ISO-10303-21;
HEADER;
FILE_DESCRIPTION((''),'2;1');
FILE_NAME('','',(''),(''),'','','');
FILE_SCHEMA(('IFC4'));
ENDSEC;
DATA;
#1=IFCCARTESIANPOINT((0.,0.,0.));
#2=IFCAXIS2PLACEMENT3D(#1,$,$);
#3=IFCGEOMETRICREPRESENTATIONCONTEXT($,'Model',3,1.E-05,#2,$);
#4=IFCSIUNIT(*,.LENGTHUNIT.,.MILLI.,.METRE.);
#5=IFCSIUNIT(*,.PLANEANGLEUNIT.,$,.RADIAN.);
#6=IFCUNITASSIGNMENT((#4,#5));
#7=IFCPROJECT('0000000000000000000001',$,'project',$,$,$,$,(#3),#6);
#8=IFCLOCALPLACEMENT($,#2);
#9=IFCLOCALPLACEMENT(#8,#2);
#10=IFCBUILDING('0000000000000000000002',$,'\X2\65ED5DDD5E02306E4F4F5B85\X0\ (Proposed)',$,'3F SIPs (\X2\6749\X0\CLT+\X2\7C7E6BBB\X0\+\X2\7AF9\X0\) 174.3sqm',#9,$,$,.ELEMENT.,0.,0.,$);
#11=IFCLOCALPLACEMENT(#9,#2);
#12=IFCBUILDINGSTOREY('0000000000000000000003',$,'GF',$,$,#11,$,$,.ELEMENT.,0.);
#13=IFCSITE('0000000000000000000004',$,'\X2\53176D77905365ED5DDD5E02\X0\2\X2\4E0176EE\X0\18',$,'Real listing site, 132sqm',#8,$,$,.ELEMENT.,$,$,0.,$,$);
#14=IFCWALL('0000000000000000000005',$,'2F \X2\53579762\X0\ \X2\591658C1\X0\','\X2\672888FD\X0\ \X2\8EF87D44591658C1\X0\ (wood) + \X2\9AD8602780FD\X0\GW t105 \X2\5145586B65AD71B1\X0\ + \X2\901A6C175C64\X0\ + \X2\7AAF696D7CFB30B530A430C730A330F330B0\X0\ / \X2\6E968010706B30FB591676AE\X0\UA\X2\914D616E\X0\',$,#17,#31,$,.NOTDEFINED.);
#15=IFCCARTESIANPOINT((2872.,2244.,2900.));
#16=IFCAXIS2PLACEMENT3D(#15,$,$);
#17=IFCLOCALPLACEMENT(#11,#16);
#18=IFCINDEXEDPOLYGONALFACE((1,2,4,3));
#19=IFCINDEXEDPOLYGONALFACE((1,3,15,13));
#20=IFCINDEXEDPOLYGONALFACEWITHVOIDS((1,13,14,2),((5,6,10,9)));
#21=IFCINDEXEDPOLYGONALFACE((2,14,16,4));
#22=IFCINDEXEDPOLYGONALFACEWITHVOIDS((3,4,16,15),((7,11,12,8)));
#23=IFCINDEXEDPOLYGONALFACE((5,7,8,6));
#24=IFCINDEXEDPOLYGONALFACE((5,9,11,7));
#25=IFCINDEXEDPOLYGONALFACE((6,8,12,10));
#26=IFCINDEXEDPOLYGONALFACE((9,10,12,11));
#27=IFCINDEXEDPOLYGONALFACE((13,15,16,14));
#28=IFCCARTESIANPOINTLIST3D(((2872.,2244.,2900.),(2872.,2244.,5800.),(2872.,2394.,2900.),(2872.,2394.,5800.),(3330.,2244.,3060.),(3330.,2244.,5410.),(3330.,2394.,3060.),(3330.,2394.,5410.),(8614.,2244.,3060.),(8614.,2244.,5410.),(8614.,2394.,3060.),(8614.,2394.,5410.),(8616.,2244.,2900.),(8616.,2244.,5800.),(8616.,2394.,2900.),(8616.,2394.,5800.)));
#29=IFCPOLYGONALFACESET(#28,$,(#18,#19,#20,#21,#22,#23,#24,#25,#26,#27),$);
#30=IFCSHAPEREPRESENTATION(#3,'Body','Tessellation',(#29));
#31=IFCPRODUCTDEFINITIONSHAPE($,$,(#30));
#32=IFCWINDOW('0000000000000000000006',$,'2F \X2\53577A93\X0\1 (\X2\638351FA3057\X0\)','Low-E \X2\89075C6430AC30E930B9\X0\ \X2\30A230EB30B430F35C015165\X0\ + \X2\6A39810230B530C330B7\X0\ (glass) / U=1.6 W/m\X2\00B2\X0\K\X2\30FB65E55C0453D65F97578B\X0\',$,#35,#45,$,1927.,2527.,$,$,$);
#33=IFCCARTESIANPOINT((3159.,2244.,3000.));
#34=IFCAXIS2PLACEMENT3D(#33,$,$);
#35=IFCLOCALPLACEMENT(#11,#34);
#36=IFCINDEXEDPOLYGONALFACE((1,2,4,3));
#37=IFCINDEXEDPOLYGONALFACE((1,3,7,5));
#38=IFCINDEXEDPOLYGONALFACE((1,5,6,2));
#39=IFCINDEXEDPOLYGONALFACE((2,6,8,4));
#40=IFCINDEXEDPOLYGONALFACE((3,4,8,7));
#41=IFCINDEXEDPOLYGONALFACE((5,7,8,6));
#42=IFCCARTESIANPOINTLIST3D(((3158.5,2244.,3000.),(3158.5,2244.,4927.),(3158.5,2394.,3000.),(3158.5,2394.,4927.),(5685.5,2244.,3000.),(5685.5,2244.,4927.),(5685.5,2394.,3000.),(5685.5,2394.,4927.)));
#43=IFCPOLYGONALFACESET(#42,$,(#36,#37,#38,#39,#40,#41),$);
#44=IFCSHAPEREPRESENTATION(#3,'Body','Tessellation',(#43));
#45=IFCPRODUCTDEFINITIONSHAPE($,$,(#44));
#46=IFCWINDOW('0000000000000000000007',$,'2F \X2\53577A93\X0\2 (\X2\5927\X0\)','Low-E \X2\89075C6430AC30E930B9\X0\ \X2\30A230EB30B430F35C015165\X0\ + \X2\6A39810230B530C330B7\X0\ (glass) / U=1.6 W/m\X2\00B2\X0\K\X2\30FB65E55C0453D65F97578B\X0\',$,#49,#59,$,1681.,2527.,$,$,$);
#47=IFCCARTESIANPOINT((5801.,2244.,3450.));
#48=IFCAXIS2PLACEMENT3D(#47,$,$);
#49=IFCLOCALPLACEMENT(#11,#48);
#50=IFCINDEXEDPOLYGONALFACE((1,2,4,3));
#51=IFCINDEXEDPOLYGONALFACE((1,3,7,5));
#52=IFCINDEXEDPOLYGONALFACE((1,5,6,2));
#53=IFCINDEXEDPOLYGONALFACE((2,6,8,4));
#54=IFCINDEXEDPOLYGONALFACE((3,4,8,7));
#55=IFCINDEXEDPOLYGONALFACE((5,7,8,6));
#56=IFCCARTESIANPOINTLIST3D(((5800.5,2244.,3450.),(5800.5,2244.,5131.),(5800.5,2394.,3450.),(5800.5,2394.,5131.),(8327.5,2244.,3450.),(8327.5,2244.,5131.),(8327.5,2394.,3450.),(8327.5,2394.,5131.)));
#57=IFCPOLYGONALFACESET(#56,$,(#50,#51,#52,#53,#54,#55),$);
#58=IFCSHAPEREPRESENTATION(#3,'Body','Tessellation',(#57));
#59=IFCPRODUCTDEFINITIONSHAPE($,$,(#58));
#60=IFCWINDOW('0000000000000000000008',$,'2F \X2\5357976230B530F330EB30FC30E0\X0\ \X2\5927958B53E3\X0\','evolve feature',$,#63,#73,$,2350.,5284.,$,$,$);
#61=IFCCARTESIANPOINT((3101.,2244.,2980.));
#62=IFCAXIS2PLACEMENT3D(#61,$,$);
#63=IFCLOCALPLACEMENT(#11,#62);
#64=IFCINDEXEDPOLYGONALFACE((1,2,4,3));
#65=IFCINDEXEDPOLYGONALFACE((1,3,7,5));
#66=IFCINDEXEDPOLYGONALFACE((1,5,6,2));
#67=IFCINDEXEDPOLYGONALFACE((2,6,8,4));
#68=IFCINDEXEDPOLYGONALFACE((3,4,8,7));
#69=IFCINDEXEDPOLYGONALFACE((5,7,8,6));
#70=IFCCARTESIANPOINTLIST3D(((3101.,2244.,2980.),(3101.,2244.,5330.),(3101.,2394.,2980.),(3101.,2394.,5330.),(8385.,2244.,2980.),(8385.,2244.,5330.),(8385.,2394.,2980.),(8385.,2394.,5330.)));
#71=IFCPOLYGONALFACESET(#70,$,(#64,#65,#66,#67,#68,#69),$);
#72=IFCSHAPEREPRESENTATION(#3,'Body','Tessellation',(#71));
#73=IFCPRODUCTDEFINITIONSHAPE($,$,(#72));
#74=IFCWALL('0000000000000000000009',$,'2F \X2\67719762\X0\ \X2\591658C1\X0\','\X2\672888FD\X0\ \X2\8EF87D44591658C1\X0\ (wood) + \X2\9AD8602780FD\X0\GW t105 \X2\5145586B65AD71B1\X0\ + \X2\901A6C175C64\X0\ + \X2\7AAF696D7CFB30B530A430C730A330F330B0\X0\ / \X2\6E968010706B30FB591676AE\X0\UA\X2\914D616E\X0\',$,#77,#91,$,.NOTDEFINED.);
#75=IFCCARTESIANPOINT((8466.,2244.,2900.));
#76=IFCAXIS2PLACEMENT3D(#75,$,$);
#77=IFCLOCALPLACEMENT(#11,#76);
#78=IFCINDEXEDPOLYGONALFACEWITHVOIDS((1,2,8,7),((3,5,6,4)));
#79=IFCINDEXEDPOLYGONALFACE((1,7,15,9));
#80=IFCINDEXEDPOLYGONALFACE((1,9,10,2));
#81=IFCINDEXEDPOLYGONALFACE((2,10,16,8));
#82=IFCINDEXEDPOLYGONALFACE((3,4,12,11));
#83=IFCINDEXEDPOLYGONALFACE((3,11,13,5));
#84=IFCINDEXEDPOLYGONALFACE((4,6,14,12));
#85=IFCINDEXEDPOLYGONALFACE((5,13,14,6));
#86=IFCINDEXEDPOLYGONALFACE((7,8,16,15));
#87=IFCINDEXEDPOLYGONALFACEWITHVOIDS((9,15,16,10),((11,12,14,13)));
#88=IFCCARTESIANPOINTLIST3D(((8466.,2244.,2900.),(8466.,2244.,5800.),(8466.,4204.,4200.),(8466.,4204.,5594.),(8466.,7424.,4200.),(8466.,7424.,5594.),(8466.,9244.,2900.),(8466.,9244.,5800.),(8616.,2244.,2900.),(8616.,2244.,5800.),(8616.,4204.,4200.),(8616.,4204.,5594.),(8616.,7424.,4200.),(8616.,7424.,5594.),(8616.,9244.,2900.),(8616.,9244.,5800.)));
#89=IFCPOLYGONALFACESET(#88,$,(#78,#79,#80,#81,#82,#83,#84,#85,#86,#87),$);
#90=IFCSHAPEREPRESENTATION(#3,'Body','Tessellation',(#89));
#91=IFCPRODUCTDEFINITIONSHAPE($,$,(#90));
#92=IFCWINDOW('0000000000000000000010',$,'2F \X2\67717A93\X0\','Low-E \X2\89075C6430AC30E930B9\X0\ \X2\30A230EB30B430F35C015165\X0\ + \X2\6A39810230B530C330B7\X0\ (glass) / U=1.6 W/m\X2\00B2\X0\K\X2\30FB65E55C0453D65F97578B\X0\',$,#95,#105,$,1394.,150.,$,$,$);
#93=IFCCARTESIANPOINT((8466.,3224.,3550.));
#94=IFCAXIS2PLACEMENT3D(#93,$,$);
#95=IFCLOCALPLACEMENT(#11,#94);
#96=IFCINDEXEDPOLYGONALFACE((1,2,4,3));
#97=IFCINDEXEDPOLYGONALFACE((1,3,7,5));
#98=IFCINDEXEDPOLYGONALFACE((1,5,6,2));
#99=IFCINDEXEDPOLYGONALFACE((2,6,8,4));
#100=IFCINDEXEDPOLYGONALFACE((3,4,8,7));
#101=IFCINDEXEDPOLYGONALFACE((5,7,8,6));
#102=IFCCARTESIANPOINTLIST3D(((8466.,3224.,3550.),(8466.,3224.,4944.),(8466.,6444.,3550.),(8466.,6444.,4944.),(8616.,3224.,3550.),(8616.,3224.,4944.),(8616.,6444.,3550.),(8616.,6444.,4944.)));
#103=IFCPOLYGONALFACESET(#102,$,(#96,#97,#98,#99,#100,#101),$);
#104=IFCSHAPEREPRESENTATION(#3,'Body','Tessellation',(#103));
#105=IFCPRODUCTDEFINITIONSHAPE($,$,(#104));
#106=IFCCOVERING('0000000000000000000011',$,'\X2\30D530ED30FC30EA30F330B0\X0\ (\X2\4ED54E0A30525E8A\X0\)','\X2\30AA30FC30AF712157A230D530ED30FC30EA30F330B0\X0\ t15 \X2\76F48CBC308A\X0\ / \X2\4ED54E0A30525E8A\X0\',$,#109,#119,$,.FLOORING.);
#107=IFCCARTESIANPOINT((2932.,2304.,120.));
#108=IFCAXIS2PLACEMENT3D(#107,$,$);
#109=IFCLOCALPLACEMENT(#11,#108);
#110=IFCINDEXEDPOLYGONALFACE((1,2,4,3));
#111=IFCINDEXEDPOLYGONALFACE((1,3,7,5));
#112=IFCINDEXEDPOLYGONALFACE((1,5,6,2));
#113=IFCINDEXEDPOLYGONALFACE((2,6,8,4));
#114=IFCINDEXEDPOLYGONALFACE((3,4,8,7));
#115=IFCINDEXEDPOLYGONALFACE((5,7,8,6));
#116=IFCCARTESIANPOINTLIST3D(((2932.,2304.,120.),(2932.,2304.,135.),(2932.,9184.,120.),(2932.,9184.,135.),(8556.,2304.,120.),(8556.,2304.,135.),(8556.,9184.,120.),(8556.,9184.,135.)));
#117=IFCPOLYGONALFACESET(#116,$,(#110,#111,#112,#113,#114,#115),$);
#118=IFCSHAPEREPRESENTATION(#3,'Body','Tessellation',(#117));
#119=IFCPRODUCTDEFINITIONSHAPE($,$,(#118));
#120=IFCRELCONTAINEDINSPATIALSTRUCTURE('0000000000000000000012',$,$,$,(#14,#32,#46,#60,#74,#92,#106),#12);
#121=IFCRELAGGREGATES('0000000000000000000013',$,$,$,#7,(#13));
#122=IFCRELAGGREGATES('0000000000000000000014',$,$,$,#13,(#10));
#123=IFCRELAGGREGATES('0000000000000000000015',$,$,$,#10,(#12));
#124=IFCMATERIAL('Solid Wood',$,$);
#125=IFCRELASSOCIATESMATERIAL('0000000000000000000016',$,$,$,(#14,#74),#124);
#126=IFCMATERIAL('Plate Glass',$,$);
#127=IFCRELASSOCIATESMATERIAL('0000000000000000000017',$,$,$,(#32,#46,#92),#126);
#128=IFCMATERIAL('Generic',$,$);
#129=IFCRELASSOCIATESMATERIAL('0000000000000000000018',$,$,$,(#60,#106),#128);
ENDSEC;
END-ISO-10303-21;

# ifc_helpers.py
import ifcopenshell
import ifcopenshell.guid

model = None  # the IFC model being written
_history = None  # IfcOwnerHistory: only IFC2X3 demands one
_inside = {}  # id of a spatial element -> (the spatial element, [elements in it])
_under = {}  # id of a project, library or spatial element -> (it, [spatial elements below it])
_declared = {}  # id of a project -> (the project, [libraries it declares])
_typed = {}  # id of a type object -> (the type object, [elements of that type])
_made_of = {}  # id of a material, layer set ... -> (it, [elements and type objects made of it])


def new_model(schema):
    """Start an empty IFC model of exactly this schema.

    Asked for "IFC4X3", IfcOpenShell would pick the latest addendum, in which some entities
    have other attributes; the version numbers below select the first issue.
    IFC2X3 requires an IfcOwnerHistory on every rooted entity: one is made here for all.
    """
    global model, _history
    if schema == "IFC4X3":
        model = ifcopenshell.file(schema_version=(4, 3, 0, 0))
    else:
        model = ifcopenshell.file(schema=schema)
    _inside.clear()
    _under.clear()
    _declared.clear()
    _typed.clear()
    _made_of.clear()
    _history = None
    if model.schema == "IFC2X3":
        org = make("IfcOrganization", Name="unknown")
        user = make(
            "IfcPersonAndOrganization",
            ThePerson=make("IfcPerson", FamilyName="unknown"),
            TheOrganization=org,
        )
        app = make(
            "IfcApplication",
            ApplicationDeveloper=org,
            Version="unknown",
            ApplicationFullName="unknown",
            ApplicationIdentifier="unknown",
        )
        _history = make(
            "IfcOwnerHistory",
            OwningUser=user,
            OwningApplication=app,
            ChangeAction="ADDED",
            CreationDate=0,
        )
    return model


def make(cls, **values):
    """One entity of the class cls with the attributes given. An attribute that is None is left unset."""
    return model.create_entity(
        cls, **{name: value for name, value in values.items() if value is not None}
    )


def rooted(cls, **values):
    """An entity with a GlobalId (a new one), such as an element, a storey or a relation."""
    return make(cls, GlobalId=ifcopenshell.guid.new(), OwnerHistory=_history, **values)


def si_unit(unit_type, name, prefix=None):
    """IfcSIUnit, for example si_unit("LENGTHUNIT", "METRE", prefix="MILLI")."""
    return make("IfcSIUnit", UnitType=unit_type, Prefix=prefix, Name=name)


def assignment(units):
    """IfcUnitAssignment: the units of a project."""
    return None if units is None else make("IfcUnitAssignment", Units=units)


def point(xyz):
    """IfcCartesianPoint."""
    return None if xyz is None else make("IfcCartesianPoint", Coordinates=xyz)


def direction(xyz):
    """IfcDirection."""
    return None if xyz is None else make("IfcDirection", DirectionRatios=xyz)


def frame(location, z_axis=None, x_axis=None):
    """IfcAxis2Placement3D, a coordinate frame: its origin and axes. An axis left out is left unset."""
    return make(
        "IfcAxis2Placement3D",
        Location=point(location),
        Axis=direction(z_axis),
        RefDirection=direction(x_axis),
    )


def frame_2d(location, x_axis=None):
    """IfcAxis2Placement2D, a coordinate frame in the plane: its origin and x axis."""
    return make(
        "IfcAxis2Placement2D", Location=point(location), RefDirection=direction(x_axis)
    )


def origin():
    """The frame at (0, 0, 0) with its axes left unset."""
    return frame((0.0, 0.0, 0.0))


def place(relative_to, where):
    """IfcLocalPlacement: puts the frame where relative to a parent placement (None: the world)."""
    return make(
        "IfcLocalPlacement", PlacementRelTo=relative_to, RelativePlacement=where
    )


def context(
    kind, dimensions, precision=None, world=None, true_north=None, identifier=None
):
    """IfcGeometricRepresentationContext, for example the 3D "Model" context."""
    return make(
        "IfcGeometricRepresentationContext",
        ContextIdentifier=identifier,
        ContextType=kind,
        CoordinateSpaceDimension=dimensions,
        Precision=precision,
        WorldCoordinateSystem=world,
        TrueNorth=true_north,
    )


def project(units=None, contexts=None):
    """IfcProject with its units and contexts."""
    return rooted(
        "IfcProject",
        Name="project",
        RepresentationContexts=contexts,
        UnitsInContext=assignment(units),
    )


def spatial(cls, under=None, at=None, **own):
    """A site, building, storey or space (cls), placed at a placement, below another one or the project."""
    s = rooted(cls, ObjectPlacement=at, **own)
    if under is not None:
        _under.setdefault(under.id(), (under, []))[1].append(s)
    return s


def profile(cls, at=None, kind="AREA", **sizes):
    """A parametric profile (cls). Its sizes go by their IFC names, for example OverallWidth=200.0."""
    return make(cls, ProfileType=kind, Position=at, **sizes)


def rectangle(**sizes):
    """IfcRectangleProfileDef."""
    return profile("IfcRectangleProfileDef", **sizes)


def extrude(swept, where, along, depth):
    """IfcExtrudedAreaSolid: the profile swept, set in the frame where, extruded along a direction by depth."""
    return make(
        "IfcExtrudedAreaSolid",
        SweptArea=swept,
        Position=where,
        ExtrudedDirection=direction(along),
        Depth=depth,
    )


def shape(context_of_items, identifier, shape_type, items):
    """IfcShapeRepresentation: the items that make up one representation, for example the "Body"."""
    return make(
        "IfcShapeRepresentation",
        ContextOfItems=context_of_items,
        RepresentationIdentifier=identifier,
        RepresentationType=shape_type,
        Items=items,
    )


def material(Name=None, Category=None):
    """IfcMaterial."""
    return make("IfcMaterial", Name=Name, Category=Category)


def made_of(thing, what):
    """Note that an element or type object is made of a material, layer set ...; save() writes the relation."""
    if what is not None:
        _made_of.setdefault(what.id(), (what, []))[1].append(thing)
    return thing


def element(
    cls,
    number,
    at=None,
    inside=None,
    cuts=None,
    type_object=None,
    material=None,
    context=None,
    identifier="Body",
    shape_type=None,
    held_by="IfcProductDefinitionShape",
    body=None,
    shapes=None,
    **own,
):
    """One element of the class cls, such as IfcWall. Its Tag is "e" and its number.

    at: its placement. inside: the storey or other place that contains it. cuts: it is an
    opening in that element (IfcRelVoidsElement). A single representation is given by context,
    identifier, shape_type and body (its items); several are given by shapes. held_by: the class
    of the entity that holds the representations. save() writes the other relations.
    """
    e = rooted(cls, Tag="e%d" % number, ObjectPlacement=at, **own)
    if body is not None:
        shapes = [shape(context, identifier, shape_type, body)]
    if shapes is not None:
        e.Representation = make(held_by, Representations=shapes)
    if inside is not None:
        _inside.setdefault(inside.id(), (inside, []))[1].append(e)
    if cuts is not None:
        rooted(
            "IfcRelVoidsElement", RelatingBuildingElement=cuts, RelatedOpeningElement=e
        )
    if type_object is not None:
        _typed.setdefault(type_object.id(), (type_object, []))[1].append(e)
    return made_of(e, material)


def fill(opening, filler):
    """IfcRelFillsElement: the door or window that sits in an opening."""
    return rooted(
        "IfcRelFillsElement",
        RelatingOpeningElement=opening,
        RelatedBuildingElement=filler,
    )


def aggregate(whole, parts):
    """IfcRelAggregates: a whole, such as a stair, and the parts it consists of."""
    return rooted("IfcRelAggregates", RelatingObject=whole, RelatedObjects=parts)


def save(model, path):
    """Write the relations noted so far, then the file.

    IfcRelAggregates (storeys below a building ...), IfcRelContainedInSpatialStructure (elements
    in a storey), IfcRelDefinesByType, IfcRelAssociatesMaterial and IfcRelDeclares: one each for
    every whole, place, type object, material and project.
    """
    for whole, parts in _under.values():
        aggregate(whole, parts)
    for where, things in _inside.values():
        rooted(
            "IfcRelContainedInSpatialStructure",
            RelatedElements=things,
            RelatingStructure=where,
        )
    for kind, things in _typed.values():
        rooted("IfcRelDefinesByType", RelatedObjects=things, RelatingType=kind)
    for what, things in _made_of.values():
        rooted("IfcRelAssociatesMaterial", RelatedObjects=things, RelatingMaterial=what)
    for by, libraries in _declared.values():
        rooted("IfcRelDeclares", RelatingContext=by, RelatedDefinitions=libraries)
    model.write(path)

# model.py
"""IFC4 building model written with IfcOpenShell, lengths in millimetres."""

from ifc_helpers import new_model, si_unit, frame, frame_2d, origin, place, context, project, spatial, rectangle, extrude, material, element, fill, save


model = new_model("IFC4")

# Units and contexts
model_context = context("Model", 3, precision=1e-05, world=origin())
ifc_project = project(units=[si_unit("LENGTHUNIT", "METRE", prefix="MILLI"), si_unit("PLANEANGLEUNIT", "RADIAN")], contexts=[model_context])

# Site, building, storey
site_placement = place(None, origin())
site = spatial("IfcSite", under=ifc_project, at=site_placement, Name="北海道旭川市2丁目18", ObjectType="Real listing site, 132sqm", CompositionType="ELEMENT", RefElevation=0.0)
building_placement = place(site_placement, origin())
building = spatial("IfcBuilding", under=site, at=building_placement, Name="旭川市の住宅 (Proposed)", ObjectType="3F SIPs (杉CLT+籾殻+竹) 174.3sqm", CompositionType="ELEMENT", ElevationOfRefHeight=0.0, ElevationOfTerrain=0.0)
storey_placement = place(building_placement, origin())
storey = spatial("IfcBuildingStorey", under=building, at=storey_placement, Name="GF", CompositionType="ELEMENT", Elevation=0.0)

# Shared definitions
ifc_material_1 = material(Name="Solid Wood")
ifc_material_2 = material(Name="Generic")

# Shared definitions
ifc_material_3 = material(Name="Plate Glass")

# Wall, openings, windows
wall_1_placement = place(storey_placement, frame((2872.0, 2244.0, 2900.0)))
wall_1 = element("IfcWall", 1, at=wall_1_placement, inside=storey, material=ifc_material_1, Name="2F 南面 外壁", Description="木製 軸組外壁 (wood) + 高性能GW t105 充填断熱 + 通気層 + 窯業系サイディング / 準耐火・外皮UA配慮", PredefinedType="NOTDEFINED", context=model_context, shape_type="SweptSolid", body=[
    extrude(rectangle(XDim=5744.0, YDim=150.0, at=frame_2d((2872.0, 75.0))), frame((2872.0, 2244.0, 2900.0)), (0.0, 0.0, 1.0), 2900.0),
])
opening_1_placement = place(storey_placement, frame((3159.0, 2244.0, 3000.0)))
opening_1 = element("IfcOpeningElement", 2, at=opening_1_placement, cuts=wall_1, PredefinedType="NOTDEFINED", context=model_context, shape_type="SweptSolid", body=[
    extrude(rectangle(XDim=2527.0, YDim=150.0, at=frame_2d((1263.0, 75.0))), frame((3159.0, 2244.0, 3000.0)), (0.0, 0.0, 1.0), 1927.0),
])
opening_2_placement = place(storey_placement, frame((5801.0, 2244.0, 3450.0)))
opening_2 = element("IfcOpeningElement", 3, at=opening_2_placement, cuts=wall_1, PredefinedType="NOTDEFINED", context=model_context, shape_type="SweptSolid", body=[
    extrude(rectangle(XDim=2527.0, YDim=150.0, at=frame_2d((1263.0, 75.0))), frame((5801.0, 2244.0, 3450.0)), (0.0, 0.0, 1.0), 1681.0),
])
opening_3_placement = place(storey_placement, frame((3101.0, 2244.0, 2980.0)))
opening_3 = element("IfcOpeningElement", 4, at=opening_3_placement, cuts=wall_1, PredefinedType="NOTDEFINED", context=model_context, shape_type="SweptSolid", body=[
    extrude(rectangle(XDim=5284.0, YDim=150.0, at=frame_2d((2642.0, 75.0))), frame((3101.0, 2244.0, 2980.0)), (0.0, 0.0, 1.0), 2350.0),
])
window_1_placement = place(storey_placement, frame((3159.0, 2244.0, 3000.0)))
window_1 = element("IfcWindow", 5, at=window_1_placement, inside=storey, material=ifc_material_3, Name="2F 南窓1 (掃出し)", Description="Low-E 複層ガラス アルゴン封入 + 樹脂サッシ (glass) / U=1.6 W/m²K・日射取得型", OverallHeight=1927.0, OverallWidth=2527.0, context=model_context, shape_type="SweptSolid", body=[
    extrude(rectangle(XDim=2527.0, YDim=150.0, at=frame_2d((1263.0, 75.0))), frame((3159.0, 2244.0, 3000.0)), (0.0, 0.0, 1.0), 1927.0),
])
fill(opening_1, window_1)
window_2_placement = place(storey_placement, frame((5801.0, 2244.0, 3450.0)))
window_2 = element("IfcWindow", 6, at=window_2_placement, inside=storey, material=ifc_material_3, Name="2F 南窓2 (大)", Description="Low-E 複層ガラス アルゴン封入 + 樹脂サッシ (glass) / U=1.6 W/m²K・日射取得型", OverallHeight=1681.0, OverallWidth=2527.0, context=model_context, shape_type="SweptSolid", body=[
    extrude(rectangle(XDim=2527.0, YDim=150.0, at=frame_2d((1263.0, 75.0))), frame((5801.0, 2244.0, 3450.0)), (0.0, 0.0, 1.0), 1681.0),
])
fill(opening_2, window_2)
window_3_placement = place(storey_placement, frame((3101.0, 2244.0, 2980.0)))
window_3 = element("IfcWindow", 7, at=window_3_placement, inside=storey, material=ifc_material_2, Name="2F 南面サンルーム 大開口", Description="evolve feature", OverallHeight=2350.0, OverallWidth=5284.0, context=model_context, shape_type="SweptSolid", body=[
    extrude(rectangle(XDim=5284.0, YDim=150.0, at=frame_2d((2642.0, 75.0))), frame((3101.0, 2244.0, 2980.0)), (0.0, 0.0, 1.0), 2350.0),
])
fill(opening_3, window_3)

# Wall, opening, window
wall_2_placement = place(storey_placement, frame((8466.0, 2244.0, 2900.0)))
wall_2 = element("IfcWall", 8, at=wall_2_placement, inside=storey, material=ifc_material_1, Name="2F 東面 外壁", Description="木製 軸組外壁 (wood) + 高性能GW t105 充填断熱 + 通気層 + 窯業系サイディング / 準耐火・外皮UA配慮", PredefinedType="NOTDEFINED", context=model_context, shape_type="SweptSolid", body=[
    extrude(rectangle(XDim=150.0, YDim=7000.0, at=frame_2d((75.0, 3500.0))), frame((8466.0, 2244.0, 2900.0)), (0.0, 0.0, 1.0), 2900.0),
])
opening_4_placement = place(storey_placement, frame((8466.0, 3224.0, 3550.0)))
opening_4 = element("IfcOpeningElement", 9, at=opening_4_placement, cuts=wall_2, PredefinedType="NOTDEFINED", context=model_context, shape_type="SweptSolid", body=[
    extrude(rectangle(XDim=150.0, YDim=3220.0, at=frame_2d((75.0, 1610.0))), frame((8466.0, 3224.0, 3550.0)), (0.0, 0.0, 1.0), 1394.0),
])
window_4_placement = place(storey_placement, frame((8466.0, 3224.0, 3550.0)))
window_4 = element("IfcWindow", 10, at=window_4_placement, inside=storey, material=ifc_material_3, Name="2F 東窓", Description="Low-E 複層ガラス アルゴン封入 + 樹脂サッシ (glass) / U=1.6 W/m²K・日射取得型", OverallHeight=1394.0, OverallWidth=150.0, context=model_context, shape_type="SweptSolid", body=[
    extrude(rectangle(XDim=150.0, YDim=3220.0, at=frame_2d((75.0, 1610.0))), frame((8466.0, 3224.0, 3550.0)), (0.0, 0.0, 1.0), 1394.0),
])
fill(opening_4, window_4)

# Covering
covering_placement = place(storey_placement, frame((2932.0, 2304.0, 120.0)))
element("IfcCovering", 11, at=covering_placement, inside=storey, material=ifc_material_2, Name="フローリング (仕上げ床)", Description="オーク無垢フローリング t15 直貼り / 仕上げ床", PredefinedType="FLOORING", context=model_context, shape_type="SweptSolid", body=[
    extrude(rectangle(XDim=5624.0, YDim=6880.0, at=frame_2d((2812.0, 3440.0))), frame((2932.0, 2304.0, 120.0)), (0.0, 0.0, 1.0), 15.0),
])

save(model, "model.ifc")
